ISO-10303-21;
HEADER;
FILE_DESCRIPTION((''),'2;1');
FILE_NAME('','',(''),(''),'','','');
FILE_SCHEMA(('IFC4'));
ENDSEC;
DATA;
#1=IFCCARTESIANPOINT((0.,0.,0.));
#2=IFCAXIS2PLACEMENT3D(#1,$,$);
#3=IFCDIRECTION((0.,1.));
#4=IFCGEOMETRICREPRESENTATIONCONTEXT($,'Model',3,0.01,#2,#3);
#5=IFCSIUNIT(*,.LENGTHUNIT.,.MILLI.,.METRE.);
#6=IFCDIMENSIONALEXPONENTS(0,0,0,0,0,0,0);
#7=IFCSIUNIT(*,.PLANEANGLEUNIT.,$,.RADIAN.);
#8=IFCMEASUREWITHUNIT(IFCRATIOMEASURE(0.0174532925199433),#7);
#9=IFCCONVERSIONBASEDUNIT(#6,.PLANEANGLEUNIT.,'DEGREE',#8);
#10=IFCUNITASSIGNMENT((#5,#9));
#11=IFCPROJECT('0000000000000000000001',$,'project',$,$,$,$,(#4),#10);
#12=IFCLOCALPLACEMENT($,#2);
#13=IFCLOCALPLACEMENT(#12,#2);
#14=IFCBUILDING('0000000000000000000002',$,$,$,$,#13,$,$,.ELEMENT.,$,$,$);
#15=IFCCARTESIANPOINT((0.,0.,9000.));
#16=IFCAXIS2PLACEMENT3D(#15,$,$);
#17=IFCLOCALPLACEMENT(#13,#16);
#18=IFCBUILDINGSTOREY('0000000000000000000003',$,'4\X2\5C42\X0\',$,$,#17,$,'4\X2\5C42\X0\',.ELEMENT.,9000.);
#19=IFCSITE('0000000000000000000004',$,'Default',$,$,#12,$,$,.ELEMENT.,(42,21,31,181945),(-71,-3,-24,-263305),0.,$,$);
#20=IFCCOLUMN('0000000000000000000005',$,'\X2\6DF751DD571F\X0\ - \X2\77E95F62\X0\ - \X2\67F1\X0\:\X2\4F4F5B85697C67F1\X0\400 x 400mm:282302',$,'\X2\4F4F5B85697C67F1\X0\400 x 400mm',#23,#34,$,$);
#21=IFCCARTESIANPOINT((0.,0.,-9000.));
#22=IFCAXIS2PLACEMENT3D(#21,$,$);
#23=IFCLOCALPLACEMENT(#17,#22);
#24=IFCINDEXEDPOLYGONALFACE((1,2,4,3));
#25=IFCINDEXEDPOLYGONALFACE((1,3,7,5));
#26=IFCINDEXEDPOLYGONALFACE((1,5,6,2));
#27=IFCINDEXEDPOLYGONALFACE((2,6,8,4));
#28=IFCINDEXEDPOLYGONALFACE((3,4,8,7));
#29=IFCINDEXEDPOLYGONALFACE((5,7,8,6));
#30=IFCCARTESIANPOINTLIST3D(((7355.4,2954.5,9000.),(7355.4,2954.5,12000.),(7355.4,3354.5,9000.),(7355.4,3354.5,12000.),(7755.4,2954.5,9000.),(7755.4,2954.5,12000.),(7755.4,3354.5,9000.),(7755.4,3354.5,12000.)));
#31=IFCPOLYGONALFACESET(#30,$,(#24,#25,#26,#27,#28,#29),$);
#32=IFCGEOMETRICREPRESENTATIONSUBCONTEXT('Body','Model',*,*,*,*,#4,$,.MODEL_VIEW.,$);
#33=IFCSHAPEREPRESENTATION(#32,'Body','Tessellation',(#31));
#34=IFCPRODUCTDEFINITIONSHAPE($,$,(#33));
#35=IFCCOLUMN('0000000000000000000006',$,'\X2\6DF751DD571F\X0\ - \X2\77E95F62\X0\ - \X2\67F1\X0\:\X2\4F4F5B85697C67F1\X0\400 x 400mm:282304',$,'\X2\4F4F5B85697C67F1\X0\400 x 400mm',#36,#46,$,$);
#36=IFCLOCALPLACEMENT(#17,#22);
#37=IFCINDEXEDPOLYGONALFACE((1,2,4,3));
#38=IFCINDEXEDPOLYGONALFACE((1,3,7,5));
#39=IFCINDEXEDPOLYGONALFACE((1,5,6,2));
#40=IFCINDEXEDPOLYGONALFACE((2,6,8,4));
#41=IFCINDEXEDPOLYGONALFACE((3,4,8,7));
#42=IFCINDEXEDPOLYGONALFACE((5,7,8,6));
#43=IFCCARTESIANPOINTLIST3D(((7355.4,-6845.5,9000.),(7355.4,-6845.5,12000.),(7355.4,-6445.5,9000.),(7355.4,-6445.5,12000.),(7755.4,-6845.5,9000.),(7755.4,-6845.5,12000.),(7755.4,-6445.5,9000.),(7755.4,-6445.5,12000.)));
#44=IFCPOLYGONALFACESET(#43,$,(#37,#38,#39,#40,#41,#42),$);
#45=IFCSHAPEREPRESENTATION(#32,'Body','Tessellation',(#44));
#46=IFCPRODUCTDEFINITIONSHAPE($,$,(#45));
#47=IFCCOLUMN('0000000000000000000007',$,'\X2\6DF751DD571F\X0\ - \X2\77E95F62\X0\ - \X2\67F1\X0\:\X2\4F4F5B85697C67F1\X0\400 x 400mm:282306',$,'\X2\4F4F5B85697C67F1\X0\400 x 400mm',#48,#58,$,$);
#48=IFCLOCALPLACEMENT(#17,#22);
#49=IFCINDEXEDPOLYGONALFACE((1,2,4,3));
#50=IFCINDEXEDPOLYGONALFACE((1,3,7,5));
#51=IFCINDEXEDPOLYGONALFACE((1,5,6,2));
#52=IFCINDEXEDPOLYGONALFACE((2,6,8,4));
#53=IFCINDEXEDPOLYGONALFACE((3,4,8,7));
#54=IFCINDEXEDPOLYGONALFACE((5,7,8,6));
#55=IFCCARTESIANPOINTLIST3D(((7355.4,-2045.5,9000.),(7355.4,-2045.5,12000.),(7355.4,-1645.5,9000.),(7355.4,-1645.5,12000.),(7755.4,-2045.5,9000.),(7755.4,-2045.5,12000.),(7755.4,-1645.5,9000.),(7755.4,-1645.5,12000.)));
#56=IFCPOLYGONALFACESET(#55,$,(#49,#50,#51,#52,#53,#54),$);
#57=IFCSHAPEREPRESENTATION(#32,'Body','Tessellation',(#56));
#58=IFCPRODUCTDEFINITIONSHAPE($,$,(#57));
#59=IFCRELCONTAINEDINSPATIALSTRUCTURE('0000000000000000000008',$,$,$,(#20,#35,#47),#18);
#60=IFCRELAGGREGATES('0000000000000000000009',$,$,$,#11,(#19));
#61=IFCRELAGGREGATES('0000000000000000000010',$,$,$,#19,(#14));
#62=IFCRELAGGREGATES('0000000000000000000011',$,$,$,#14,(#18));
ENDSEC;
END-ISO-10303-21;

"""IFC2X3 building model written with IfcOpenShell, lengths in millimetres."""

from ifc_helpers import new_model, entity, si_unit, converted_unit, direction, frame, origin, origin_2d_with_axis, place, context, subcontext, project, spatial, rectangle, extrude, source, transform, mapped, element, save


model = new_model("IFC2X3")

# Units and contexts
model_context = context("Model", 3, precision=0.01, world=origin(), true_north=direction((0.0, 1.0)))
body_context = subcontext(model_context, "Body", "Model", "MODEL_VIEW")
ifc_project = project(units=[si_unit("LENGTHUNIT", "METRE", prefix="MILLI"), converted_unit("PLANEANGLEUNIT", "DEGREE", entity("IfcRatioMeasure", 0.0174532925199433), si_unit("PLANEANGLEUNIT", "RADIAN"), dimensions=[0, 0, 0, 0, 0, 0, 0])], contexts=[model_context])

# Site, building, storey
site_placement = place(None, origin())
site = spatial("IfcSite", under=ifc_project, at=site_placement, Name="Default", CompositionType="ELEMENT", RefLatitude=(42, 21, 31, 181945), RefLongitude=(-71, -3, -24, -263305), RefElevation=0.0)
building_placement = place(site_placement, origin())
building = spatial("IfcBuilding", under=site, at=building_placement, CompositionType="ELEMENT")
storey_placement = place(building_placement, frame((0.0, 0.0, 9000.0)))
storey = spatial("IfcBuildingStorey", under=building, at=storey_placement, Name="4层", LongName="4层", CompositionType="ELEMENT", Elevation=9000.0)

# Columns
shared_shape_1 = source(origin(), body_context, "Body", "SweptSolid", [
    extrude(rectangle(XDim=400.0, YDim=400.0, at=origin_2d_with_axis()), frame((7555.4, 3154.5, 9000.0), z_axis=(0.0, 0.0, 1.0), x_axis=(0.0, -1.0, 0.0)), (0.0, 0.0, 1.0), 3000.0),
])
column_1_placement = place(storey_placement, frame((0.0, 0.0, -9000.0)))
element("IfcColumn", 1, at=column_1_placement, inside=storey, Name="混凝土 - 矩形 - 柱:住宅楼柱400 x 400mm:282302", ObjectType="住宅楼柱400 x 400mm", context=body_context, shape_type="MappedRepresentation", body=[
    mapped(shared_shape_1, transform((0.0, 0.0, 0.0), scale=1.0)),
])
shared_shape_2 = source(origin(), body_context, "Body", "SweptSolid", [
    extrude(rectangle(XDim=400.0, YDim=400.0, at=origin_2d_with_axis()), frame((7555.4, -6645.5, 9000.0), z_axis=(0.0, 0.0, 1.0), x_axis=(0.0, -1.0, 0.0)), (0.0, 0.0, 1.0), 3000.0),
])
column_2_placement = place(storey_placement, frame((0.0, 0.0, -9000.0)))
element("IfcColumn", 2, at=column_2_placement, inside=storey, Name="混凝土 - 矩形 - 柱:住宅楼柱400 x 400mm:282304", ObjectType="住宅楼柱400 x 400mm", context=body_context, shape_type="MappedRepresentation", body=[
    mapped(shared_shape_2, transform((0.0, 0.0, 0.0), scale=1.0)),
])
shared_shape_3 = source(origin(), body_context, "Body", "SweptSolid", [
    extrude(rectangle(XDim=400.0, YDim=400.0, at=origin_2d_with_axis()), frame((7555.4, -1845.5, 9000.0), z_axis=(0.0, 0.0, 1.0), x_axis=(0.0, -1.0, 0.0)), (0.0, 0.0, 1.0), 3000.0),
])
column_3_placement = place(storey_placement, frame((0.0, 0.0, -9000.0)))
element("IfcColumn", 3, at=column_3_placement, inside=storey, Name="混凝土 - 矩形 - 柱:住宅楼柱400 x 400mm:282306", ObjectType="住宅楼柱400 x 400mm", context=body_context, shape_type="MappedRepresentation", body=[
    mapped(shared_shape_3, transform((0.0, 0.0, 0.0), scale=1.0)),
])

save(model, "model.ifc")
